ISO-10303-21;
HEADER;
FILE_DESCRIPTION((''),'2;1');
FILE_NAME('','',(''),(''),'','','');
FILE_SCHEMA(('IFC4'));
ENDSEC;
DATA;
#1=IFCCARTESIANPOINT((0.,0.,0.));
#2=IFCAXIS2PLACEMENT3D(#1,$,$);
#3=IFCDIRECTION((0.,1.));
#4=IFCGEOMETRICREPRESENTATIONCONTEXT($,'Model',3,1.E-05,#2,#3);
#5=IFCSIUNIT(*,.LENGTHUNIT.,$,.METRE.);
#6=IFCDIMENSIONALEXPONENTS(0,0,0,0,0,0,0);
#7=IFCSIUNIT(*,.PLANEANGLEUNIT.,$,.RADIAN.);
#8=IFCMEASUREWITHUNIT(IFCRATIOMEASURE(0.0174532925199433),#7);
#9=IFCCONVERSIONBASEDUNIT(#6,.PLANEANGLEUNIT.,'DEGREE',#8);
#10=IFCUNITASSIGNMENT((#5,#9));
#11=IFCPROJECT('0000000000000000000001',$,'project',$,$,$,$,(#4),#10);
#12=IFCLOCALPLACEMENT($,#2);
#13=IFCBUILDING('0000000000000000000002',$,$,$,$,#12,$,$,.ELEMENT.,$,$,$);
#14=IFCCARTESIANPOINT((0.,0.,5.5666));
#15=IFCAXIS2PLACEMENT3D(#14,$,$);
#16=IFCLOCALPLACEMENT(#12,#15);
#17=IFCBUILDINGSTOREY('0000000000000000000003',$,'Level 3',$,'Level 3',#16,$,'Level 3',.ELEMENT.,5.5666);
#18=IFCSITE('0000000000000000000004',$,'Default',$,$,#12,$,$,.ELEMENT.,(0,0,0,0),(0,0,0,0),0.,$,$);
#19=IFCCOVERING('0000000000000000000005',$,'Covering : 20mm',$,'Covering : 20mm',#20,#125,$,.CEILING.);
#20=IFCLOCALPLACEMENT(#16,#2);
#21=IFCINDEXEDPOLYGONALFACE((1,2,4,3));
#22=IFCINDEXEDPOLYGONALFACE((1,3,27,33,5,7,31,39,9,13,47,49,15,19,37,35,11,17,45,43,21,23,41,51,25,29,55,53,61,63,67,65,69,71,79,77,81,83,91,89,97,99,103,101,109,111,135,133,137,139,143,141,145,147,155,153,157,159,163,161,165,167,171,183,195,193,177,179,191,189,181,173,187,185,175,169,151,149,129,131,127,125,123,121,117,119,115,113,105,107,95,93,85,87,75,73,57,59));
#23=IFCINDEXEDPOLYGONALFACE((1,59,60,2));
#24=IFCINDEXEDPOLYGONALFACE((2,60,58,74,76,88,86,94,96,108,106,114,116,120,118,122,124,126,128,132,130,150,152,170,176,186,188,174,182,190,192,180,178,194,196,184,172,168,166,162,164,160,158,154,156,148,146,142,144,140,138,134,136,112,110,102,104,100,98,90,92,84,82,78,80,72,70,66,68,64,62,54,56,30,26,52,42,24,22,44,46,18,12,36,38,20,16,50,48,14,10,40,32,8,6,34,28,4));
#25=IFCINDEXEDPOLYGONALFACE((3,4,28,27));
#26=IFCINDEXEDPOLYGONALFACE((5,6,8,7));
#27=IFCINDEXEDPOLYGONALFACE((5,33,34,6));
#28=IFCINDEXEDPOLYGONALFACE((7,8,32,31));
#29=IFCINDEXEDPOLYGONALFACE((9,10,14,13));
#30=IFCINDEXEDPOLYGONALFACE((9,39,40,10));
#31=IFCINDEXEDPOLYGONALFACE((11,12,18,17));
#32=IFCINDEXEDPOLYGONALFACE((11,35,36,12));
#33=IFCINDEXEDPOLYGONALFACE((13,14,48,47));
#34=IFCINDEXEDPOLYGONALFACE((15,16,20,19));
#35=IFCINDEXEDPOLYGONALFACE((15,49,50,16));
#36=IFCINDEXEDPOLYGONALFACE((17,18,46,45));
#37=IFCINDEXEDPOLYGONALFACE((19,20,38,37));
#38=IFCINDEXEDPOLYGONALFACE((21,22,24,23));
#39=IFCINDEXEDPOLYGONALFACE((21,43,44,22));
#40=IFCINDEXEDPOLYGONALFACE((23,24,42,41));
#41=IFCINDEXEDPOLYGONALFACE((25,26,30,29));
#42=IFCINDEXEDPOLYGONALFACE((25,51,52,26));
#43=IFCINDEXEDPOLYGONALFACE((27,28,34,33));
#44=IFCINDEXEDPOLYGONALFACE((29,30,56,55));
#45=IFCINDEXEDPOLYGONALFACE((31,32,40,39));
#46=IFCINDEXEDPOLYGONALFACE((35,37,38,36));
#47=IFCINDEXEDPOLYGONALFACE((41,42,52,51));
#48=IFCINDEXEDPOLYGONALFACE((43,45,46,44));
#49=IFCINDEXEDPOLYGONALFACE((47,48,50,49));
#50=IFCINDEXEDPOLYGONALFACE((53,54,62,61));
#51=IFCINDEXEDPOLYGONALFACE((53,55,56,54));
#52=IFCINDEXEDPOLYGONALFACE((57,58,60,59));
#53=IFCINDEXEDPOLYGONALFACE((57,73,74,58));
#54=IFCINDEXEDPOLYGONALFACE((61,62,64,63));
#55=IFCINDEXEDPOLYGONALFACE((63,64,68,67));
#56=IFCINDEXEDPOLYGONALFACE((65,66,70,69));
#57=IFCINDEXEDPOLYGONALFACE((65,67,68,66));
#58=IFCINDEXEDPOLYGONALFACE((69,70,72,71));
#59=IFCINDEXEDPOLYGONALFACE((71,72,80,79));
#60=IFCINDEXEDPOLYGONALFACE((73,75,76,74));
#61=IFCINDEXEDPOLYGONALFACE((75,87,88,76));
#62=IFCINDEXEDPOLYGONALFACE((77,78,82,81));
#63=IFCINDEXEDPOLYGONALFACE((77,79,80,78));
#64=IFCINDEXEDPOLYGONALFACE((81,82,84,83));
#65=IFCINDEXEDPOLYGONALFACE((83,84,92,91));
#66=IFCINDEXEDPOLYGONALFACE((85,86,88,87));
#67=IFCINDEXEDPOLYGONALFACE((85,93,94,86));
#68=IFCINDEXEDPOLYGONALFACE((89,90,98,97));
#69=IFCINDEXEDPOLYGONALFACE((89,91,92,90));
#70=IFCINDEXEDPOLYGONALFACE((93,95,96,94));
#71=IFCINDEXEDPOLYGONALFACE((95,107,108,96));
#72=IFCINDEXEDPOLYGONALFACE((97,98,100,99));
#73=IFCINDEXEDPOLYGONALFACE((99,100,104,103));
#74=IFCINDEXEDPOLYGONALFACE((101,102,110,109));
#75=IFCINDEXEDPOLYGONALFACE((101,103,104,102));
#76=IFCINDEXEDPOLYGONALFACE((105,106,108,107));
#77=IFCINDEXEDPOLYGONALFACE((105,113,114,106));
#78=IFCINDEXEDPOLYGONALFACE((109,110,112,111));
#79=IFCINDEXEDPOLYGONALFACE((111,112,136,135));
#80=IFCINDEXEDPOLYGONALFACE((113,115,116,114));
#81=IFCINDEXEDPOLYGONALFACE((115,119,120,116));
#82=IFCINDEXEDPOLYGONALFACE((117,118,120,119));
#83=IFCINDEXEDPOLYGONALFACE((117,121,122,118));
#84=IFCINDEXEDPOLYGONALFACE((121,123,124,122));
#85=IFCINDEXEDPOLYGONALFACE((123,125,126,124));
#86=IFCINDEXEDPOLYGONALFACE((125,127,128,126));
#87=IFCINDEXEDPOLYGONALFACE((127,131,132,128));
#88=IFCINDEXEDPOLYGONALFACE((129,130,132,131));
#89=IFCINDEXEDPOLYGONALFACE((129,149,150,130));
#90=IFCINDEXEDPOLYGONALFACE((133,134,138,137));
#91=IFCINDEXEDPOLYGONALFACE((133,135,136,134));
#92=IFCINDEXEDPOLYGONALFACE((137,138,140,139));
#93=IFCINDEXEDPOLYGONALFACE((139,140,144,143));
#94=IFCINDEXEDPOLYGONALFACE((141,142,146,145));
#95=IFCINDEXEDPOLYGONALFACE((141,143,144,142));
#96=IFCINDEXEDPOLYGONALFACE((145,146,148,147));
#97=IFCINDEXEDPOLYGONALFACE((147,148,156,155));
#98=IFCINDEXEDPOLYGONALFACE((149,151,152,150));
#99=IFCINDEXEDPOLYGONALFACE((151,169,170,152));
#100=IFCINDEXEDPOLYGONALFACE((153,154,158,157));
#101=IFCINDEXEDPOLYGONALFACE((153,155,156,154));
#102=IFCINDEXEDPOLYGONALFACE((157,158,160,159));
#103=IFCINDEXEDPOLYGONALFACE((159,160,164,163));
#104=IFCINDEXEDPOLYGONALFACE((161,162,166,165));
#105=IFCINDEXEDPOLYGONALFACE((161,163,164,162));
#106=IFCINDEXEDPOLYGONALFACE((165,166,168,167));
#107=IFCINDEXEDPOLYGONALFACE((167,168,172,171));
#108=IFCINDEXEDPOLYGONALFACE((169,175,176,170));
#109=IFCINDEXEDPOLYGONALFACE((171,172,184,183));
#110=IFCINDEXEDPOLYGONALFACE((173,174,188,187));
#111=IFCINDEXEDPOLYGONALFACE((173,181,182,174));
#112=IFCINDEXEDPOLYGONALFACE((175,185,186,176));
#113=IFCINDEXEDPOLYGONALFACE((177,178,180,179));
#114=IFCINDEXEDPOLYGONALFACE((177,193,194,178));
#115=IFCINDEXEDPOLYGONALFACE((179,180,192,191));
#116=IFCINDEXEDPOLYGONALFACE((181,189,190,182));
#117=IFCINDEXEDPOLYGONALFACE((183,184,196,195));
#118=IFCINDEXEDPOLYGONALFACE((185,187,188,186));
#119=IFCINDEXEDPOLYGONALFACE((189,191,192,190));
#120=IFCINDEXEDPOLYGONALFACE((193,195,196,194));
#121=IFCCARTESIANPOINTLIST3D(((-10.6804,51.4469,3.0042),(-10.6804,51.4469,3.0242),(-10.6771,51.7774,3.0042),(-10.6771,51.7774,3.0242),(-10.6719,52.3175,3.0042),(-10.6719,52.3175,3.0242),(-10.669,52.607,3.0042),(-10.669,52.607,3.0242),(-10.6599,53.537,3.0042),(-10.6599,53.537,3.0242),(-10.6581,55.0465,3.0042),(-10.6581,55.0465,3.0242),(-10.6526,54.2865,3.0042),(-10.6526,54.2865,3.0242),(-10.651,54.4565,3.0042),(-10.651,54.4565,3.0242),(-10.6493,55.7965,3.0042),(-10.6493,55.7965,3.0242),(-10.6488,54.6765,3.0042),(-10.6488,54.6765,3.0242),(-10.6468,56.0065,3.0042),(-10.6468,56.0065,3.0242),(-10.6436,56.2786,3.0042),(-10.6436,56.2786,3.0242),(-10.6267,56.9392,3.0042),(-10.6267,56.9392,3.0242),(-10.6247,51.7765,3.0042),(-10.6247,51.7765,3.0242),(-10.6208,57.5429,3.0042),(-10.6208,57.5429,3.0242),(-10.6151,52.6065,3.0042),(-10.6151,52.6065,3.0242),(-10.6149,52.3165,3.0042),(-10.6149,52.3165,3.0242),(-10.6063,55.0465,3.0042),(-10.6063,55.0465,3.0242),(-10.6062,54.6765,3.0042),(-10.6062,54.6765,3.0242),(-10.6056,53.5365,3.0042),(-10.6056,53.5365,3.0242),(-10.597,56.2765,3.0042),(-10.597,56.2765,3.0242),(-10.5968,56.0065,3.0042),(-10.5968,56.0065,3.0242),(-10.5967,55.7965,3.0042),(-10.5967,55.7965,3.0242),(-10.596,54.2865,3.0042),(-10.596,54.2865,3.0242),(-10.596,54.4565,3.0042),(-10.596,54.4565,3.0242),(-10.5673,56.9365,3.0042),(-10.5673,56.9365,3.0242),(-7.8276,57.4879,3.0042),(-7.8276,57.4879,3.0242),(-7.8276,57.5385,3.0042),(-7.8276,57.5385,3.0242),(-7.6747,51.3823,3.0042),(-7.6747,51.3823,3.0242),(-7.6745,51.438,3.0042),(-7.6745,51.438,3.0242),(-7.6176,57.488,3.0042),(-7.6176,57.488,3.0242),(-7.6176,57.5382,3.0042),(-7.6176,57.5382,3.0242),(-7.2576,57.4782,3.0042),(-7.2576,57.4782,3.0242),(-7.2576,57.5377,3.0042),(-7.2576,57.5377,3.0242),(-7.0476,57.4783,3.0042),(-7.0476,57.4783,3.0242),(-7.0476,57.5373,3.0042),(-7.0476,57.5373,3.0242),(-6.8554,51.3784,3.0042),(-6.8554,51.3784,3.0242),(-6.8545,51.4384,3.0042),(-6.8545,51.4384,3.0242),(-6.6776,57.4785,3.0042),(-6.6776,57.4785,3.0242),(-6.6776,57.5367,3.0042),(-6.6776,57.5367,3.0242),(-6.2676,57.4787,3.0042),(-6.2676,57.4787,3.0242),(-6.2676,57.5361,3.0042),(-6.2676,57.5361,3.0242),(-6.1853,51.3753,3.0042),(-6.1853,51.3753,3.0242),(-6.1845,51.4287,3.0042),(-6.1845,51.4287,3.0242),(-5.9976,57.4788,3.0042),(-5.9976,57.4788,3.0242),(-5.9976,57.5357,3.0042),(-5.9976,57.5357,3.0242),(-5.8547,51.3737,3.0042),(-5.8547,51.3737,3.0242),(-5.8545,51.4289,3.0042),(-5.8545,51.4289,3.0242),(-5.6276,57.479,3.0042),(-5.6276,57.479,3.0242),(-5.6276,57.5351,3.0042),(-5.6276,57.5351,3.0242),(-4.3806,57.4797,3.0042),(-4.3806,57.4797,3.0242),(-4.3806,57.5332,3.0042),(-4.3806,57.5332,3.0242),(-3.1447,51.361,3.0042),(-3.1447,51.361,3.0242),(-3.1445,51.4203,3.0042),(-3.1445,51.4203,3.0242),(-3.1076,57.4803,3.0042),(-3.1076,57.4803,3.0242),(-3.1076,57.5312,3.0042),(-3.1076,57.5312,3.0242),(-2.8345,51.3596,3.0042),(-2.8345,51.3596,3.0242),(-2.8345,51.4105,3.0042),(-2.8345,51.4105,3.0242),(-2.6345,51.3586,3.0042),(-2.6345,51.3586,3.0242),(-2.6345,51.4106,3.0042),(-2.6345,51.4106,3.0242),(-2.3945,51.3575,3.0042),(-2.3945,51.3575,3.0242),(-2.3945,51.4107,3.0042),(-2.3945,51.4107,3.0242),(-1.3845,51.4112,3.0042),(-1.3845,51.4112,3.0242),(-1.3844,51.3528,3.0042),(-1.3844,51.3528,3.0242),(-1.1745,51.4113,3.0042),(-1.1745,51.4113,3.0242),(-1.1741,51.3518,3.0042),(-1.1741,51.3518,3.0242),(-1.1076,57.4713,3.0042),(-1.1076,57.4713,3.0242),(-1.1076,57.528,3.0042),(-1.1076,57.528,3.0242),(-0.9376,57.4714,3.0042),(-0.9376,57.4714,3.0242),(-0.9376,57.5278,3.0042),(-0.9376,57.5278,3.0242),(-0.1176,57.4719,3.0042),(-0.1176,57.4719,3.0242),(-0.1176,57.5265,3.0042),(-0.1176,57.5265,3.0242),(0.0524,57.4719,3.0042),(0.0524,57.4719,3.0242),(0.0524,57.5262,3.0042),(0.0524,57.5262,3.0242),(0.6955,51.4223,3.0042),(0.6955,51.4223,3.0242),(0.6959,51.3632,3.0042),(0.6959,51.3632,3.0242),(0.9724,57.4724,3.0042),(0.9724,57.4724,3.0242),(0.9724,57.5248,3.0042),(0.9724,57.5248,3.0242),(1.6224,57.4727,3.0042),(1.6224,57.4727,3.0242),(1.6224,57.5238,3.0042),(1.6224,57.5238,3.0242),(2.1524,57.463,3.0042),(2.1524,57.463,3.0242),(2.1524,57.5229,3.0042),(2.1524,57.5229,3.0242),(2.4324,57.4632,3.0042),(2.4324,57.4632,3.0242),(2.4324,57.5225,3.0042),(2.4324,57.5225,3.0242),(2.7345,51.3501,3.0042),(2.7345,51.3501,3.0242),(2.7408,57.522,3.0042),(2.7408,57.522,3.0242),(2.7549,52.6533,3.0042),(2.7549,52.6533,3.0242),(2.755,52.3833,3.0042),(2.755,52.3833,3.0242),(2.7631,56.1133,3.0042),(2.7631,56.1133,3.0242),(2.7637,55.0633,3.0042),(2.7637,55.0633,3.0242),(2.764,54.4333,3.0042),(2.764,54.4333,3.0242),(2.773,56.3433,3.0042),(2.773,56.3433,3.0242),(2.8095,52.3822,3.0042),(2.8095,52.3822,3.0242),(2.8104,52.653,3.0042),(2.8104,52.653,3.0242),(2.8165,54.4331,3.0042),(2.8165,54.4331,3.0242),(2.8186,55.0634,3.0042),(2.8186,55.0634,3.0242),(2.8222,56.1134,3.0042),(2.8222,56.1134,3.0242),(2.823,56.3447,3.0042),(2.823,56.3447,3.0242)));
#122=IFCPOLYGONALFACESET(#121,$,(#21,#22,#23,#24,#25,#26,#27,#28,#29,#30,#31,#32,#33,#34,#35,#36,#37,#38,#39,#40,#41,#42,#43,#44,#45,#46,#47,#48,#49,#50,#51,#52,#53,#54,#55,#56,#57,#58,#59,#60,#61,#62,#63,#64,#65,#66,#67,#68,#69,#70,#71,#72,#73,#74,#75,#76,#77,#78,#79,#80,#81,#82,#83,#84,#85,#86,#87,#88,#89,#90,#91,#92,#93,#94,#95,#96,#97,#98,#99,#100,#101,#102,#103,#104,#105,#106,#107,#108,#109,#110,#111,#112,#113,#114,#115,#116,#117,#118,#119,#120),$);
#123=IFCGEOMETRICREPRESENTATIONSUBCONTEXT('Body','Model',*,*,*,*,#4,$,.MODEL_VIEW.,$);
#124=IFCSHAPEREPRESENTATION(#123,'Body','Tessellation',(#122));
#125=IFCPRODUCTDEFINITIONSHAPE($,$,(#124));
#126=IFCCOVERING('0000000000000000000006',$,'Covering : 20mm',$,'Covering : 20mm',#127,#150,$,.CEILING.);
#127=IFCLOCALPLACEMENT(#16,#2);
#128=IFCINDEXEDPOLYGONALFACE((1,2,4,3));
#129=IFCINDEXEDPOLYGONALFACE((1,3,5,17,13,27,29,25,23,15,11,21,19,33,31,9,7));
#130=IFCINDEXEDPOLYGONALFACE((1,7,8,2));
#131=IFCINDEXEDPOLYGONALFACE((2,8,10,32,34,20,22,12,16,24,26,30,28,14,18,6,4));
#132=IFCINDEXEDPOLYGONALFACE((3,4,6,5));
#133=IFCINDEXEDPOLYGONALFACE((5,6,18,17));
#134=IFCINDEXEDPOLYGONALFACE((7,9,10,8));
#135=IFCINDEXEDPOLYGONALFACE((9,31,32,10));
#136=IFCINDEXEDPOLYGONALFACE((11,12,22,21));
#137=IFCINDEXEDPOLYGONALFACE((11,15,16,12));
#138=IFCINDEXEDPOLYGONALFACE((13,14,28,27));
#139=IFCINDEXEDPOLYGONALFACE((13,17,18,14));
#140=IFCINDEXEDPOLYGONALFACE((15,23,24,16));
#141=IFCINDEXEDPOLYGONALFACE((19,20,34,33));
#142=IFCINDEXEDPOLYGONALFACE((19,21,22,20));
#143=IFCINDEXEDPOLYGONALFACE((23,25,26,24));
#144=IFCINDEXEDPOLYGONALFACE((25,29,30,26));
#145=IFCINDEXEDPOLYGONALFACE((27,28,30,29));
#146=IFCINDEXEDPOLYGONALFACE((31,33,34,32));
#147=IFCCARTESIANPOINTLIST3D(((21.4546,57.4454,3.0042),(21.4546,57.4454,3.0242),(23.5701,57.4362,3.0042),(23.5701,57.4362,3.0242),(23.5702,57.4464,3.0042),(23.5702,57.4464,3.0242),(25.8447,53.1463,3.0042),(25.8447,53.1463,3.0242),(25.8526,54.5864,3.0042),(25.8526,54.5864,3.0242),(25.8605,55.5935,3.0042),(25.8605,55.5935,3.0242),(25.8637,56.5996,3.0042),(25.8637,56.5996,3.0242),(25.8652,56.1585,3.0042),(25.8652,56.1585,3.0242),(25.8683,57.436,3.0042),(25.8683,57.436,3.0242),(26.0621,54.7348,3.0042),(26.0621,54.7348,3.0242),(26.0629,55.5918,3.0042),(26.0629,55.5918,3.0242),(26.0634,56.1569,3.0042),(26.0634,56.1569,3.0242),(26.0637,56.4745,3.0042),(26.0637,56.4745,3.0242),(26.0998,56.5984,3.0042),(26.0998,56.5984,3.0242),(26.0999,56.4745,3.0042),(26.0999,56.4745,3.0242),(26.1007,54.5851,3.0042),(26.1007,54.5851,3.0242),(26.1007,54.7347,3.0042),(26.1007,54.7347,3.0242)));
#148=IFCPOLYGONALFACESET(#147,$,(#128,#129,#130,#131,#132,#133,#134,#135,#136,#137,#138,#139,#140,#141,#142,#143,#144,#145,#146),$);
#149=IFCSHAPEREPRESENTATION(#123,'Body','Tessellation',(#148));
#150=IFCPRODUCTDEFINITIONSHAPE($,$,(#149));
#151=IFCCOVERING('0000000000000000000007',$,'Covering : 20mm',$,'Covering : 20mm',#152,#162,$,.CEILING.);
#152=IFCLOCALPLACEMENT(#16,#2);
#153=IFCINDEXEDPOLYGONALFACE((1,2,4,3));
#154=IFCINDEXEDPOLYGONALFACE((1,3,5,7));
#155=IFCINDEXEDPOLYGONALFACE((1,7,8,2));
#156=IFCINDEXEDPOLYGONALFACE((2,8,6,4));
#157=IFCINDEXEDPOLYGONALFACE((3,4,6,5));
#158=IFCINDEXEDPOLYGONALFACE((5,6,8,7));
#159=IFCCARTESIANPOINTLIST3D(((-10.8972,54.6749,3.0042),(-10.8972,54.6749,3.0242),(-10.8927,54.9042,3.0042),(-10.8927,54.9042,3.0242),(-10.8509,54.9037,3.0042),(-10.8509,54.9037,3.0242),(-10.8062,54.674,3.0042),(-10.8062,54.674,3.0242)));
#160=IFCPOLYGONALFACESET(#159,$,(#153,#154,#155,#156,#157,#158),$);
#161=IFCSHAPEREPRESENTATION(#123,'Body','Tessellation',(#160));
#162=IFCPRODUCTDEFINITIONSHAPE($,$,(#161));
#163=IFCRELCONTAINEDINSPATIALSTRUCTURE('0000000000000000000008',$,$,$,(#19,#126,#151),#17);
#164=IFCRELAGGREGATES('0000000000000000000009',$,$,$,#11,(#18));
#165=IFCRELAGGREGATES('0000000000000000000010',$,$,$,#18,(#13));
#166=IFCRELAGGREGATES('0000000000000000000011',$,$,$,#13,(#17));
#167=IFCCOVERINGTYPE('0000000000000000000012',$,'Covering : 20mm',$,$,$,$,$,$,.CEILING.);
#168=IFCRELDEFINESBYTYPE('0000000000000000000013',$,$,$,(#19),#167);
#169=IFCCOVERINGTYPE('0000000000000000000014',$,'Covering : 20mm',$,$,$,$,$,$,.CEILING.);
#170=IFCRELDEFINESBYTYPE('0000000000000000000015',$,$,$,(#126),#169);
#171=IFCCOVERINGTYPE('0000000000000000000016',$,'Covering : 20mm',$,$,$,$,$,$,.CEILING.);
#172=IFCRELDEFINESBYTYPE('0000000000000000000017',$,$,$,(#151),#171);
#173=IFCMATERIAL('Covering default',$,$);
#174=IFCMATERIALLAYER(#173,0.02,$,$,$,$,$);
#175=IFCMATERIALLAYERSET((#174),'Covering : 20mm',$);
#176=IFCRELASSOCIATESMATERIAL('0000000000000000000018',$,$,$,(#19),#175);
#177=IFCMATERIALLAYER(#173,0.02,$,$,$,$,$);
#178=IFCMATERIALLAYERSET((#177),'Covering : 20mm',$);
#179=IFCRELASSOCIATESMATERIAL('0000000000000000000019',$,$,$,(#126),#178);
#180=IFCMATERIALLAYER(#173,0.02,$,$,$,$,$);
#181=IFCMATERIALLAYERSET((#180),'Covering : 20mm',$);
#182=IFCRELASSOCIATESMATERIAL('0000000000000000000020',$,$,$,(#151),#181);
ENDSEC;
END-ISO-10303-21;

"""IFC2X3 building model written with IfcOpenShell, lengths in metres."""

from ifc_helpers import new_model, entity, si_unit, converted_unit, direction, frame, origin, origin_with_axes, place, context, subcontext, project, spatial, polyline, outline, extrude, material, layer, layer_set, layer_usage, type_object, element, save


model = new_model("IFC2X3")

# Units and contexts
model_context = context("Model", 3, precision=1e-05, world=origin(), true_north=direction((0.0, 1.0)))
body_context = subcontext(model_context, "Body", "Model", "MODEL_VIEW")
ifc_project = project(units=[si_unit("LENGTHUNIT", "METRE"), converted_unit("PLANEANGLEUNIT", "DEGREE", entity("IfcRatioMeasure", 0.0174532925199433), si_unit("PLANEANGLEUNIT", "RADIAN"), dimensions=[0, 0, 0, 0, 0, 0, 0])], contexts=[model_context])

# Site, building, storey
placement = place(None, origin())
site = spatial("IfcSite", under=ifc_project, at=placement, Name="Default", CompositionType="ELEMENT", RefLatitude=(0, 0, 0, 0), RefLongitude=(0, 0, 0, 0), RefElevation=0.0)
building = spatial("IfcBuilding", under=site, at=placement, CompositionType="ELEMENT")
storey_placement = place(placement, frame((0.0, 0.0, 5.5666)))
storey = spatial("IfcBuildingStorey", under=building, at=storey_placement, Name="Level 3", ObjectType="Level 3", LongName="Level 3", CompositionType="ELEMENT", Elevation=5.5666)

# Coverings
ifc_material_1 = material(Name="Covering default")
ifc_layer_1 = layer(ifc_material_1, 0.02)
ifc_layer_set_1 = layer_set([ifc_layer_1], Name="Covering : 20mm")
ifc_layer_usage_1 = layer_usage(ifc_layer_set_1, "AXIS3", "POSITIVE", 0.0)
covering_type_1 = type_object("IfcCoveringType", Name="Covering : 20mm", PredefinedType="CEILING")
covering_1_placement = place(placement, frame((0.0, 0.0, 8.5708)))
element("IfcCovering", 1, at=covering_1_placement, inside=storey, type_object=covering_type_1, material=ifc_layer_usage_1, Name="Covering : 20mm", ObjectType="Covering : 20mm", PredefinedType="CEILING", context=body_context, shape_type="SweptSolid", body=[
    extrude(outline(polyline([(-10.6771, 51.7774), (-10.6247, 51.7765), (-10.6149, 52.3165), (-10.6719, 52.3175), (-10.669, 52.607), (-10.6151, 52.6065), (-10.6056, 53.5365), (-10.6599, 53.537), (-10.6526, 54.2865), (-10.596, 54.2865), (-10.596, 54.4565), (-10.651, 54.4565), (-10.6488, 54.6765), (-10.6062, 54.6765), (-10.6063, 55.0465), (-10.6581, 55.0465), (-10.6493, 55.7965), (-10.5967, 55.7965), (-10.5968, 56.0065), (-10.6468, 56.0065), (-10.6436, 56.2786), (-10.597, 56.2765), (-10.5673, 56.9365), (-10.6267, 56.9392), (-10.6208, 57.5429), (-7.8276, 57.5385), (-7.8276, 57.4879), (-7.6176, 57.488), (-7.6176, 57.5382), (-7.2576, 57.5377), (-7.2576, 57.4782), (-7.0476, 57.4783), (-7.0476, 57.5373), (-6.6776, 57.5367), (-6.6776, 57.4785), (-6.2676, 57.4787), (-6.2676, 57.5361), (-5.9976, 57.5357), (-5.9976, 57.4788), (-5.6276, 57.479), (-5.6276, 57.5351), (-4.3806, 57.5332), (-4.3806, 57.4797), (-3.1076, 57.4803), (-3.1076, 57.5312), (-1.1076, 57.528), (-1.1076, 57.4713), (-0.9376, 57.4714), (-0.9376, 57.5278), (-0.1176, 57.5265), (-0.1176, 57.4719), (0.0524, 57.4719), (0.0524, 57.5262), (0.9724, 57.5248), (0.9724, 57.4724), (1.6224, 57.4727), (1.6224, 57.5238), (2.1524, 57.5229), (2.1524, 57.463), (2.4324, 57.4632), (2.4324, 57.5225), (2.7408, 57.522), (2.773, 56.3433), (2.823, 56.3447), (2.8222, 56.1134), (2.7631, 56.1133), (2.7637, 55.0633), (2.8186, 55.0634), (2.8165, 54.4331), (2.764, 54.4333), (2.7549, 52.6533), (2.8104, 52.653), (2.8095, 52.3822), (2.755, 52.3833), (2.7345, 51.3501), (0.6959, 51.3632), (0.6955, 51.4223), (-1.1745, 51.4113), (-1.1741, 51.3518), (-1.3844, 51.3528), (-1.3845, 51.4112), (-2.3945, 51.4107), (-2.3945, 51.3575), (-2.6345, 51.3586), (-2.6345, 51.4106), (-2.8345, 51.4105), (-2.8345, 51.3596), (-3.1447, 51.361), (-3.1445, 51.4203), (-5.8545, 51.4289), (-5.8547, 51.3737), (-6.1853, 51.3753), (-6.1845, 51.4287), (-6.8545, 51.4384), (-6.8554, 51.3784), (-7.6747, 51.3823), (-7.6745, 51.438), (-10.6804, 51.4469), (-10.6771, 51.7774)])), origin_with_axes(), (0.0, 0.0, 1.0), 0.02),
])
ifc_layer_2 = layer(ifc_material_1, 0.02)
ifc_layer_set_2 = layer_set([ifc_layer_2], Name="Covering : 20mm")
ifc_layer_usage_2 = layer_usage(ifc_layer_set_2, "AXIS3", "POSITIVE", 0.0)
covering_type_2 = type_object("IfcCoveringType", Name="Covering : 20mm", PredefinedType="CEILING")
covering_2_placement = place(placement, frame((0.0, 0.0, 8.5708)))
element("IfcCovering", 2, at=covering_2_placement, inside=storey, type_object=covering_type_2, material=ifc_layer_usage_2, Name="Covering : 20mm", ObjectType="Covering : 20mm", PredefinedType="CEILING", context=body_context, shape_type="SweptSolid", body=[
    extrude(outline(polyline([(25.8447, 53.1463), (25.8526, 54.5864), (26.1007, 54.5851), (26.1007, 54.7347), (26.0621, 54.7348), (26.0629, 55.5918), (25.8605, 55.5935), (25.8652, 56.1585), (26.0634, 56.1569), (26.0637, 56.4745), (26.0999, 56.4745), (26.0998, 56.5984), (25.8637, 56.5996), (25.8683, 57.436), (23.5702, 57.4464), (23.5701, 57.4362), (21.4546, 57.4454), (25.8447, 53.1463)])), origin_with_axes(), (0.0, 0.0, 1.0), 0.02),
])
ifc_layer_3 = layer(ifc_material_1, 0.02)
ifc_layer_set_3 = layer_set([ifc_layer_3], Name="Covering : 20mm")
ifc_layer_usage_3 = layer_usage(ifc_layer_set_3, "AXIS3", "POSITIVE", 0.0)
covering_type_3 = type_object("IfcCoveringType", Name="Covering : 20mm", PredefinedType="CEILING")
covering_3_placement = place(placement, frame((0.0, 0.0, 8.5708)))
element("IfcCovering", 3, at=covering_3_placement, inside=storey, type_object=covering_type_3, material=ifc_layer_usage_3, Name="Covering : 20mm", ObjectType="Covering : 20mm", PredefinedType="CEILING", context=body_context, shape_type="SweptSolid", body=[
    extrude(outline(polyline([(-10.8927, 54.9042), (-10.8509, 54.9037), (-10.8062, 54.674), (-10.8972, 54.6749), (-10.8927, 54.9042)])), origin_with_axes(), (0.0, 0.0, 1.0), 0.02),
])

save(model, "model.ifc")
